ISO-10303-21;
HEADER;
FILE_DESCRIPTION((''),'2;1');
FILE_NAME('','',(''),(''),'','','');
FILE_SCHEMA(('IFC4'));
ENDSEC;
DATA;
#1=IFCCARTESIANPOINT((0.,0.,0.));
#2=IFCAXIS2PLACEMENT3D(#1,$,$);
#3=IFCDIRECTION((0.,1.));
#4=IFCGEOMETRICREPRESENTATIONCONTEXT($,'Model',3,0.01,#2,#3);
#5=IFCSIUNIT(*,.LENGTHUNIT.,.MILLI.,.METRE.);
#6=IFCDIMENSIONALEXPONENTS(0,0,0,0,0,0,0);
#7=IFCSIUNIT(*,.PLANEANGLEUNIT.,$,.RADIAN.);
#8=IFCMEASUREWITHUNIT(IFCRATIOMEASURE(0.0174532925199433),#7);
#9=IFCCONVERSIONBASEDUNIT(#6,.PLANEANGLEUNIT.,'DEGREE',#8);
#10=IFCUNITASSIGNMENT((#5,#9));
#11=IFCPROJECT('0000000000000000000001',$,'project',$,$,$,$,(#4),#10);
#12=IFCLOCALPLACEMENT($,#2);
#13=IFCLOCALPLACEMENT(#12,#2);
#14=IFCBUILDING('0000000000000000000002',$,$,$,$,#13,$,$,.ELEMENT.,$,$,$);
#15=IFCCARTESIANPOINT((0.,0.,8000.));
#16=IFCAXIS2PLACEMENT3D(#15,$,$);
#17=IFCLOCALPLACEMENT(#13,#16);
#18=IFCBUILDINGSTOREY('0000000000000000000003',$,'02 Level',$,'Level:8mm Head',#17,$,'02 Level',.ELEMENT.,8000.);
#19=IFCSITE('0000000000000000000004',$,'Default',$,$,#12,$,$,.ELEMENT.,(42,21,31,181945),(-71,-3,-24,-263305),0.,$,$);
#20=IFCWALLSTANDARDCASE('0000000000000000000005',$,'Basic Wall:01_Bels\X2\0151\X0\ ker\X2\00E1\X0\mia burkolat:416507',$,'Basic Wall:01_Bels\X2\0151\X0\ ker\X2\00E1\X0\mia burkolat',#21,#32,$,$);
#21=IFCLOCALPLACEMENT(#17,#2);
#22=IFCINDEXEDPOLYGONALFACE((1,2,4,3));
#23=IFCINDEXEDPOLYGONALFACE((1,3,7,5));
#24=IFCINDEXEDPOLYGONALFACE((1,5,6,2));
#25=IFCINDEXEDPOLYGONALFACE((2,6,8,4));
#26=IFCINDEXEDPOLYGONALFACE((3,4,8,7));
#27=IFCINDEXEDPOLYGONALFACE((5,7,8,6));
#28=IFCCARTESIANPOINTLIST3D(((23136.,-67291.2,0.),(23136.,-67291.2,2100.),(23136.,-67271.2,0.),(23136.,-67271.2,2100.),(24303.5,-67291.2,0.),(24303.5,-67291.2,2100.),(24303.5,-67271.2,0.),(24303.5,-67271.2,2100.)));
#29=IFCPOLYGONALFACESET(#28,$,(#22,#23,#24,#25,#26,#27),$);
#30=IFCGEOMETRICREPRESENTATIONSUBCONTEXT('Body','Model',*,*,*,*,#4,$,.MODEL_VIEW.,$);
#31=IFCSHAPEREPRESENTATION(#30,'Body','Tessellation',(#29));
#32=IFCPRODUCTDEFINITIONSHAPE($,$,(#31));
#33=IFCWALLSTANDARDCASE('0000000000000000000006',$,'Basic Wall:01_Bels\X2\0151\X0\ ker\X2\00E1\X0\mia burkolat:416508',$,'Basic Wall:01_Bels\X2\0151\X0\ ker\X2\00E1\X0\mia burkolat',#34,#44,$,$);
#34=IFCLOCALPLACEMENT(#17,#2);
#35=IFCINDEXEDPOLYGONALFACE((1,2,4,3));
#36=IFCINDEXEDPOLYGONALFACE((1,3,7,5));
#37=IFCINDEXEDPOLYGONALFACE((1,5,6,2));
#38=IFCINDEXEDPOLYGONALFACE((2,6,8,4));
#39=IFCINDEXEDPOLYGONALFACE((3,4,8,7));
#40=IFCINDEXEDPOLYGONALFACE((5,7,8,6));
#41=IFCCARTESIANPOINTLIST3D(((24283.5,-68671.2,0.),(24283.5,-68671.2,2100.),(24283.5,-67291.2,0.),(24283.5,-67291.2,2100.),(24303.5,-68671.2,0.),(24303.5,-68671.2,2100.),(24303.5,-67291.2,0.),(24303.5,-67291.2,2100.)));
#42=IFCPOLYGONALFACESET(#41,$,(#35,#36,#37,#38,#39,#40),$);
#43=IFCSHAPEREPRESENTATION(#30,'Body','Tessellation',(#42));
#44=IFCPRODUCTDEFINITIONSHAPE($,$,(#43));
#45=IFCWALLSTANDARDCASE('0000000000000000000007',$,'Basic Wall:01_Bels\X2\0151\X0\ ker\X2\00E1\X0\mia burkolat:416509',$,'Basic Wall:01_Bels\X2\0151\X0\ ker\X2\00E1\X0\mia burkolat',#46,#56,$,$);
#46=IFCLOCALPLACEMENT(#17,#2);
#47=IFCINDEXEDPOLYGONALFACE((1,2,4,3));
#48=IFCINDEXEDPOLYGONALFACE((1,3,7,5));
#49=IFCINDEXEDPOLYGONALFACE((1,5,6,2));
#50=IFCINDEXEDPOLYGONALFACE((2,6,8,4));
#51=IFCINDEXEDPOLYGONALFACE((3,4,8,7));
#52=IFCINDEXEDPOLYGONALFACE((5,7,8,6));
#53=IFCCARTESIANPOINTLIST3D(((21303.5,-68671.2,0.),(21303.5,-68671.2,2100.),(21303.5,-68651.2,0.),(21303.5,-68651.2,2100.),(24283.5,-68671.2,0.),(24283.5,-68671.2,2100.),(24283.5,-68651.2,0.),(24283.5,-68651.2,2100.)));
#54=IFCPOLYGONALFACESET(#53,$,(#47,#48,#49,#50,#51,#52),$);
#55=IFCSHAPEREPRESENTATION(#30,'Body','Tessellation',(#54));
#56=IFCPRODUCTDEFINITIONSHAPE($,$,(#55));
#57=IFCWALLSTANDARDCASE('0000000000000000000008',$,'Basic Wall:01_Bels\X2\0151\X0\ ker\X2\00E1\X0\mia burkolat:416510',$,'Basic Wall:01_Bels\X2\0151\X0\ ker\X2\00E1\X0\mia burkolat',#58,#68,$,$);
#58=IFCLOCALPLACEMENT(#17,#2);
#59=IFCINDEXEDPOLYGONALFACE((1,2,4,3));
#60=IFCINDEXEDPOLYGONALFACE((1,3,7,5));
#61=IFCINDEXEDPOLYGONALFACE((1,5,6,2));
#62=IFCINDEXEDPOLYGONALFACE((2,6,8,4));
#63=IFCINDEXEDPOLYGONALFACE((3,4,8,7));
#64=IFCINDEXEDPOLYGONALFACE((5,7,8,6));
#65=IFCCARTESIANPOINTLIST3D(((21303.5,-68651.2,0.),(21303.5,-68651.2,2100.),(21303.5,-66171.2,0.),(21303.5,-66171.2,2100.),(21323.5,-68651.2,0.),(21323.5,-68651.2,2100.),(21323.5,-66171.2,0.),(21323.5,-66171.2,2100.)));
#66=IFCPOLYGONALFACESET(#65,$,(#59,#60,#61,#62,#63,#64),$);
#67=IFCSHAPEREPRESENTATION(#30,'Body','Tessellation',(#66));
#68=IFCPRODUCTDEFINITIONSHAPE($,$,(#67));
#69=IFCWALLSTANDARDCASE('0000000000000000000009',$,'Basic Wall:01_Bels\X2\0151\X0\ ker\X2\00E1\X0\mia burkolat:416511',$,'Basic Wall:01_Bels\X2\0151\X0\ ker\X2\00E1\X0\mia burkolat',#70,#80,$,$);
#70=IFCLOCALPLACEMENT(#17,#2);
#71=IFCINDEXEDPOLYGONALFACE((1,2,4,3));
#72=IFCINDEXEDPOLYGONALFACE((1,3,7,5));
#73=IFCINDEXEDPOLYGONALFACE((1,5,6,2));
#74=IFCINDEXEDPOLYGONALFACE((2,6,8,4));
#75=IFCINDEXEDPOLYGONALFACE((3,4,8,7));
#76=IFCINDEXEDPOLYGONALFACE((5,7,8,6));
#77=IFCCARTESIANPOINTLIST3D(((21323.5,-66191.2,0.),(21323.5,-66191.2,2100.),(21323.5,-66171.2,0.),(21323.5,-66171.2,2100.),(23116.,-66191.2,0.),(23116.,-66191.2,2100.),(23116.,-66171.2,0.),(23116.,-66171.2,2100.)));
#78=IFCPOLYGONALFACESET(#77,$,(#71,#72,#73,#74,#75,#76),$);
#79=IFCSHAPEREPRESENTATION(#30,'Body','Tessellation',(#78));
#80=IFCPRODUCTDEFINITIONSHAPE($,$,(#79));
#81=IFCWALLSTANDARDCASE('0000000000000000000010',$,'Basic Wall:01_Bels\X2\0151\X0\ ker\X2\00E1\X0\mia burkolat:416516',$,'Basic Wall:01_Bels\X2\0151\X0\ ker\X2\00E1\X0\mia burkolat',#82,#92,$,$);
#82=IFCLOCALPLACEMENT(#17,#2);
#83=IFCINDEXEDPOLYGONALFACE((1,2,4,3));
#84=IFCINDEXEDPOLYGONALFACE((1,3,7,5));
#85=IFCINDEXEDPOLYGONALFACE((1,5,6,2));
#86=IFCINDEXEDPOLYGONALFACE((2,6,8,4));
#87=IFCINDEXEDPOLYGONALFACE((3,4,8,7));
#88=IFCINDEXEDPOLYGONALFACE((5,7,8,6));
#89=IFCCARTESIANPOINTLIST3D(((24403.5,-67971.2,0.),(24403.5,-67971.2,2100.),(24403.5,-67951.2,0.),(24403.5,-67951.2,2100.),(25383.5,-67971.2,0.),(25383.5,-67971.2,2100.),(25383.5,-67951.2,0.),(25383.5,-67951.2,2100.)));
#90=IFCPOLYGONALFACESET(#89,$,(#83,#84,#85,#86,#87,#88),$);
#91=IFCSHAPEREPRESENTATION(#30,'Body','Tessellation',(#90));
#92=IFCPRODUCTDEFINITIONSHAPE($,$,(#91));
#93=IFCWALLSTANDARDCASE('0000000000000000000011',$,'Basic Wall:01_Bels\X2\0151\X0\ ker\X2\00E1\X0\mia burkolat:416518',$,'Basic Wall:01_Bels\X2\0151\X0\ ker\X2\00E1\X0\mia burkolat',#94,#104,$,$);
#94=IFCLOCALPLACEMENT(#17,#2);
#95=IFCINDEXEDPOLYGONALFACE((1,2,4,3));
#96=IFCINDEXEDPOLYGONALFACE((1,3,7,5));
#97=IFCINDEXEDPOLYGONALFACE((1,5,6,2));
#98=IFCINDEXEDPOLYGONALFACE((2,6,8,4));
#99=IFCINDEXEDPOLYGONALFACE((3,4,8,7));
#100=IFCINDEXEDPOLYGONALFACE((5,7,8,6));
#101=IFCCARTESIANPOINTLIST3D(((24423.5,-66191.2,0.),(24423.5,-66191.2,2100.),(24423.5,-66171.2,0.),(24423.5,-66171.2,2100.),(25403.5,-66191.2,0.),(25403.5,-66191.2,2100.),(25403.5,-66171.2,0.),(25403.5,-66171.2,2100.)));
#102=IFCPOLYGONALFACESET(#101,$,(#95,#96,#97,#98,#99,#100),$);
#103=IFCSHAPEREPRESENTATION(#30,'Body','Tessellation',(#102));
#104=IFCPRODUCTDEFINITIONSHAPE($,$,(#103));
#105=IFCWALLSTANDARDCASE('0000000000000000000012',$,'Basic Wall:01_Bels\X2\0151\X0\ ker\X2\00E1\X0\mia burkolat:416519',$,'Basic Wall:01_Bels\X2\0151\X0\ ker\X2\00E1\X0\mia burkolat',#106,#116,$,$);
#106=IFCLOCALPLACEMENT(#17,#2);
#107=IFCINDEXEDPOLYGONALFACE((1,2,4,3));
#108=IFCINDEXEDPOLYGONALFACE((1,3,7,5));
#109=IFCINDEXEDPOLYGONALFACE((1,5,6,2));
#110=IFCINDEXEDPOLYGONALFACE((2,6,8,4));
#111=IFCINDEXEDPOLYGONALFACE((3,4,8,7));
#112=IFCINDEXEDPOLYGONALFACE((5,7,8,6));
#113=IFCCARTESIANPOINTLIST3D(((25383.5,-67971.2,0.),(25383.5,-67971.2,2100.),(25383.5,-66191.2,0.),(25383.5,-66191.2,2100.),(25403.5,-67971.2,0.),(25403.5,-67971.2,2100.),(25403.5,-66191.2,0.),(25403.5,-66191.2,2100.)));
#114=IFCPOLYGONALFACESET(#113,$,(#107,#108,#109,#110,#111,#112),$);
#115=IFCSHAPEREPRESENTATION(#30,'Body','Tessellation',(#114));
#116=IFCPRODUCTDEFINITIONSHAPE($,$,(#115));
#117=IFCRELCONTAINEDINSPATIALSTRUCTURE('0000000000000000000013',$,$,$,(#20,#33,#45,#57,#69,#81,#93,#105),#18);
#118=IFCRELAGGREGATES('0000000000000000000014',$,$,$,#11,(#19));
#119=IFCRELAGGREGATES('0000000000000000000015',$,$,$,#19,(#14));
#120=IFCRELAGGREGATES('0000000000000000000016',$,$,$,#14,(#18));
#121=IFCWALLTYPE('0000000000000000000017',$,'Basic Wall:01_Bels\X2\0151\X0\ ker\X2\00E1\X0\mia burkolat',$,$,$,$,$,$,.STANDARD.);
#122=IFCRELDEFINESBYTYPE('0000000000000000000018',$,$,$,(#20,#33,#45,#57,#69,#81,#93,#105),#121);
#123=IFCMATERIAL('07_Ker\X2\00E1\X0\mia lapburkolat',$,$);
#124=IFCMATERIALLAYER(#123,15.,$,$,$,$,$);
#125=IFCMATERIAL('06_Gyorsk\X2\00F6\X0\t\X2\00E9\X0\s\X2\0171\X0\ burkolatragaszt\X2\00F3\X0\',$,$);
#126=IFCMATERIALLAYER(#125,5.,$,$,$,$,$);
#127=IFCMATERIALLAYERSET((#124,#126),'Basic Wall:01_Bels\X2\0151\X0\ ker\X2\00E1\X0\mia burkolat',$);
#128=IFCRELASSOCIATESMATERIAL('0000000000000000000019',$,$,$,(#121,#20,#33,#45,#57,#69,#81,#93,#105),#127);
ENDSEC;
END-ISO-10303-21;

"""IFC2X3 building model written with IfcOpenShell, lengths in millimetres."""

from ifc_helpers import new_model, entity, si_unit, converted_unit, direction, frame, frame_2d, origin, place, context, subcontext, project, spatial, rectangle, extrude, material, layer, layer_set, layer_usage, type_object, element, save


model = new_model("IFC2X3")

# Units and contexts
model_context = context("Model", 3, precision=0.01, world=origin(), true_north=direction((0.0, 1.0)))
body_context = subcontext(model_context, "Body", "Model", "MODEL_VIEW")
ifc_project = project(units=[si_unit("LENGTHUNIT", "METRE", prefix="MILLI"), converted_unit("PLANEANGLEUNIT", "DEGREE", entity("IfcRatioMeasure", 0.0174532925199433), si_unit("PLANEANGLEUNIT", "RADIAN"), dimensions=[0, 0, 0, 0, 0, 0, 0])], contexts=[model_context])

# Site, building, storey
site_placement = place(None, origin())
site = spatial("IfcSite", under=ifc_project, at=site_placement, Name="Default", CompositionType="ELEMENT", RefLatitude=(42, 21, 31, 181945), RefLongitude=(-71, -3, -24, -263305), RefElevation=0.0)
building_placement = place(site_placement, origin())
building = spatial("IfcBuilding", under=site, at=building_placement, CompositionType="ELEMENT")
storey_placement = place(building_placement, frame((0.0, 0.0, 8000.0)))
storey = spatial("IfcBuildingStorey", under=building, at=storey_placement, Name="02 Level", ObjectType="Level:8mm Head", LongName="02 Level", CompositionType="ELEMENT", Elevation=8000.0)

# Shared definitions
ifc_material_1 = material(Name="07_Kerámia lapburkolat")
ifc_layer_1 = layer(ifc_material_1, 15.0)
ifc_material_2 = material(Name="06_Gyorskötésű burkolatragasztó")
ifc_layer_2 = layer(ifc_material_2, 5.0)
ifc_layer_set_1 = layer_set([ifc_layer_1, ifc_layer_2], Name="Basic Wall:01_Belső kerámia burkolat")
wall_type_1 = type_object("IfcWallType", Name="Basic Wall:01_Belső kerámia burkolat", PredefinedType="STANDARD", material=ifc_layer_set_1)

# Walls
ifc_layer_usage_1 = layer_usage(ifc_layer_set_1, "AXIS2", "POSITIVE", -10.0)
wall_1_placement = place(storey_placement, frame((23136.0, -67281.2, 0.0)))
element("IfcWallStandardCase", 1, at=wall_1_placement, inside=storey, type_object=wall_type_1, material=ifc_layer_usage_1, Name="Basic Wall:01_Belső kerámia burkolat:416507", ObjectType="Basic Wall:01_Belső kerámia burkolat", context=body_context, shape_type="SweptSolid", body=[
    extrude(rectangle(XDim=1167.5, YDim=20.0, at=frame_2d((583.7, 0.0), x_axis=(-1.0, 0.0))), origin(), (0.0, 0.0, 1.0), 2100.0),
])
ifc_layer_usage_2 = layer_usage(ifc_layer_set_1, "AXIS2", "POSITIVE", -10.0)
wall_2_placement = place(storey_placement, frame((24293.5, -67291.2, 0.0), z_axis=(0.0, 0.0, 1.0), x_axis=(0.0, -1.0, 0.0)))
element("IfcWallStandardCase", 2, at=wall_2_placement, inside=storey, type_object=wall_type_1, material=ifc_layer_usage_2, Name="Basic Wall:01_Belső kerámia burkolat:416508", ObjectType="Basic Wall:01_Belső kerámia burkolat", context=body_context, shape_type="SweptSolid", body=[
    extrude(rectangle(XDim=1380.0, YDim=20.0, at=frame_2d((690.0, 0.0), x_axis=(-1.0, 0.0))), origin(), (0.0, 0.0, 1.0), 2100.0),
])
ifc_layer_usage_3 = layer_usage(ifc_layer_set_1, "AXIS2", "POSITIVE", -10.0)
wall_3_placement = place(storey_placement, frame((24283.5, -68661.2, 0.0), z_axis=(0.0, 0.0, 1.0), x_axis=(-1.0, 0.0, 0.0)))
element("IfcWallStandardCase", 3, at=wall_3_placement, inside=storey, type_object=wall_type_1, material=ifc_layer_usage_3, Name="Basic Wall:01_Belső kerámia burkolat:416509", ObjectType="Basic Wall:01_Belső kerámia burkolat", context=body_context, shape_type="SweptSolid", body=[
    extrude(rectangle(XDim=2980.0, YDim=20.0, at=frame_2d((1490.0, 0.0), x_axis=(-1.0, 0.0))), origin(), (0.0, 0.0, 1.0), 2100.0),
])
ifc_layer_usage_4 = layer_usage(ifc_layer_set_1, "AXIS2", "POSITIVE", -10.0)
wall_4_placement = place(storey_placement, frame((21313.5, -68651.2, 0.0), z_axis=(0.0, 0.0, 1.0), x_axis=(0.0, 1.0, 0.0)))
element("IfcWallStandardCase", 4, at=wall_4_placement, inside=storey, type_object=wall_type_1, material=ifc_layer_usage_4, Name="Basic Wall:01_Belső kerámia burkolat:416510", ObjectType="Basic Wall:01_Belső kerámia burkolat", context=body_context, shape_type="SweptSolid", body=[
    extrude(rectangle(XDim=2480.0, YDim=20.0, at=frame_2d((1240.0, 0.0), x_axis=(-1.0, 0.0))), origin(), (0.0, 0.0, 1.0), 2100.0),
])
ifc_layer_usage_5 = layer_usage(ifc_layer_set_1, "AXIS2", "POSITIVE", -10.0)
wall_5_placement = place(storey_placement, frame((21323.5, -66181.2, 0.0)))
element("IfcWallStandardCase", 5, at=wall_5_placement, inside=storey, type_object=wall_type_1, material=ifc_layer_usage_5, Name="Basic Wall:01_Belső kerámia burkolat:416511", ObjectType="Basic Wall:01_Belső kerámia burkolat", context=body_context, shape_type="SweptSolid", body=[
    extrude(rectangle(XDim=1792.5, YDim=20.0, at=frame_2d((896.3, 0.0), x_axis=(-1.0, 0.0))), origin(), (0.0, 0.0, 1.0), 2100.0),
])
ifc_layer_usage_6 = layer_usage(ifc_layer_set_1, "AXIS2", "NEGATIVE", 10.0)
wall_6_placement = place(storey_placement, frame((24403.5, -67961.2, 0.0)))
element("IfcWallStandardCase", 6, at=wall_6_placement, inside=storey, type_object=wall_type_1, material=ifc_layer_usage_6, Name="Basic Wall:01_Belső kerámia burkolat:416516", ObjectType="Basic Wall:01_Belső kerámia burkolat", context=body_context, shape_type="SweptSolid", body=[
    extrude(rectangle(XDim=980.0, YDim=20.0, at=frame_2d((490.0, 0.0), x_axis=(-1.0, 0.0))), origin(), (0.0, 0.0, 1.0), 2100.0),
])

# Walls
ifc_layer_usage_7 = layer_usage(ifc_layer_set_1, "AXIS2", "NEGATIVE", 10.0)
wall_7_placement = place(storey_placement, frame((25403.5, -66181.2, 0.0), z_axis=(0.0, 0.0, 1.0), x_axis=(-1.0, 0.0, 0.0)))
element("IfcWallStandardCase", 7, at=wall_7_placement, inside=storey, type_object=wall_type_1, material=ifc_layer_usage_7, Name="Basic Wall:01_Belső kerámia burkolat:416518", ObjectType="Basic Wall:01_Belső kerámia burkolat", context=body_context, shape_type="SweptSolid", body=[
    extrude(rectangle(XDim=980.0, YDim=20.0, at=frame_2d((490.0, 0.0), x_axis=(-1.0, 0.0))), origin(), (0.0, 0.0, 1.0), 2100.0),
])
ifc_layer_usage_8 = layer_usage(ifc_layer_set_1, "AXIS2", "NEGATIVE", 10.0)
wall_8_placement = place(storey_placement, frame((25393.5, -67971.2, 0.0), z_axis=(0.0, 0.0, 1.0), x_axis=(0.0, 1.0, 0.0)))
element("IfcWallStandardCase", 8, at=wall_8_placement, inside=storey, type_object=wall_type_1, material=ifc_layer_usage_8, Name="Basic Wall:01_Belső kerámia burkolat:416519", ObjectType="Basic Wall:01_Belső kerámia burkolat", context=body_context, shape_type="SweptSolid", body=[
    extrude(rectangle(XDim=1780.0, YDim=20.0, at=frame_2d((890.0, 0.0), x_axis=(-1.0, 0.0))), origin(), (0.0, 0.0, 1.0), 2100.0),
])

save(model, "model.ifc")
